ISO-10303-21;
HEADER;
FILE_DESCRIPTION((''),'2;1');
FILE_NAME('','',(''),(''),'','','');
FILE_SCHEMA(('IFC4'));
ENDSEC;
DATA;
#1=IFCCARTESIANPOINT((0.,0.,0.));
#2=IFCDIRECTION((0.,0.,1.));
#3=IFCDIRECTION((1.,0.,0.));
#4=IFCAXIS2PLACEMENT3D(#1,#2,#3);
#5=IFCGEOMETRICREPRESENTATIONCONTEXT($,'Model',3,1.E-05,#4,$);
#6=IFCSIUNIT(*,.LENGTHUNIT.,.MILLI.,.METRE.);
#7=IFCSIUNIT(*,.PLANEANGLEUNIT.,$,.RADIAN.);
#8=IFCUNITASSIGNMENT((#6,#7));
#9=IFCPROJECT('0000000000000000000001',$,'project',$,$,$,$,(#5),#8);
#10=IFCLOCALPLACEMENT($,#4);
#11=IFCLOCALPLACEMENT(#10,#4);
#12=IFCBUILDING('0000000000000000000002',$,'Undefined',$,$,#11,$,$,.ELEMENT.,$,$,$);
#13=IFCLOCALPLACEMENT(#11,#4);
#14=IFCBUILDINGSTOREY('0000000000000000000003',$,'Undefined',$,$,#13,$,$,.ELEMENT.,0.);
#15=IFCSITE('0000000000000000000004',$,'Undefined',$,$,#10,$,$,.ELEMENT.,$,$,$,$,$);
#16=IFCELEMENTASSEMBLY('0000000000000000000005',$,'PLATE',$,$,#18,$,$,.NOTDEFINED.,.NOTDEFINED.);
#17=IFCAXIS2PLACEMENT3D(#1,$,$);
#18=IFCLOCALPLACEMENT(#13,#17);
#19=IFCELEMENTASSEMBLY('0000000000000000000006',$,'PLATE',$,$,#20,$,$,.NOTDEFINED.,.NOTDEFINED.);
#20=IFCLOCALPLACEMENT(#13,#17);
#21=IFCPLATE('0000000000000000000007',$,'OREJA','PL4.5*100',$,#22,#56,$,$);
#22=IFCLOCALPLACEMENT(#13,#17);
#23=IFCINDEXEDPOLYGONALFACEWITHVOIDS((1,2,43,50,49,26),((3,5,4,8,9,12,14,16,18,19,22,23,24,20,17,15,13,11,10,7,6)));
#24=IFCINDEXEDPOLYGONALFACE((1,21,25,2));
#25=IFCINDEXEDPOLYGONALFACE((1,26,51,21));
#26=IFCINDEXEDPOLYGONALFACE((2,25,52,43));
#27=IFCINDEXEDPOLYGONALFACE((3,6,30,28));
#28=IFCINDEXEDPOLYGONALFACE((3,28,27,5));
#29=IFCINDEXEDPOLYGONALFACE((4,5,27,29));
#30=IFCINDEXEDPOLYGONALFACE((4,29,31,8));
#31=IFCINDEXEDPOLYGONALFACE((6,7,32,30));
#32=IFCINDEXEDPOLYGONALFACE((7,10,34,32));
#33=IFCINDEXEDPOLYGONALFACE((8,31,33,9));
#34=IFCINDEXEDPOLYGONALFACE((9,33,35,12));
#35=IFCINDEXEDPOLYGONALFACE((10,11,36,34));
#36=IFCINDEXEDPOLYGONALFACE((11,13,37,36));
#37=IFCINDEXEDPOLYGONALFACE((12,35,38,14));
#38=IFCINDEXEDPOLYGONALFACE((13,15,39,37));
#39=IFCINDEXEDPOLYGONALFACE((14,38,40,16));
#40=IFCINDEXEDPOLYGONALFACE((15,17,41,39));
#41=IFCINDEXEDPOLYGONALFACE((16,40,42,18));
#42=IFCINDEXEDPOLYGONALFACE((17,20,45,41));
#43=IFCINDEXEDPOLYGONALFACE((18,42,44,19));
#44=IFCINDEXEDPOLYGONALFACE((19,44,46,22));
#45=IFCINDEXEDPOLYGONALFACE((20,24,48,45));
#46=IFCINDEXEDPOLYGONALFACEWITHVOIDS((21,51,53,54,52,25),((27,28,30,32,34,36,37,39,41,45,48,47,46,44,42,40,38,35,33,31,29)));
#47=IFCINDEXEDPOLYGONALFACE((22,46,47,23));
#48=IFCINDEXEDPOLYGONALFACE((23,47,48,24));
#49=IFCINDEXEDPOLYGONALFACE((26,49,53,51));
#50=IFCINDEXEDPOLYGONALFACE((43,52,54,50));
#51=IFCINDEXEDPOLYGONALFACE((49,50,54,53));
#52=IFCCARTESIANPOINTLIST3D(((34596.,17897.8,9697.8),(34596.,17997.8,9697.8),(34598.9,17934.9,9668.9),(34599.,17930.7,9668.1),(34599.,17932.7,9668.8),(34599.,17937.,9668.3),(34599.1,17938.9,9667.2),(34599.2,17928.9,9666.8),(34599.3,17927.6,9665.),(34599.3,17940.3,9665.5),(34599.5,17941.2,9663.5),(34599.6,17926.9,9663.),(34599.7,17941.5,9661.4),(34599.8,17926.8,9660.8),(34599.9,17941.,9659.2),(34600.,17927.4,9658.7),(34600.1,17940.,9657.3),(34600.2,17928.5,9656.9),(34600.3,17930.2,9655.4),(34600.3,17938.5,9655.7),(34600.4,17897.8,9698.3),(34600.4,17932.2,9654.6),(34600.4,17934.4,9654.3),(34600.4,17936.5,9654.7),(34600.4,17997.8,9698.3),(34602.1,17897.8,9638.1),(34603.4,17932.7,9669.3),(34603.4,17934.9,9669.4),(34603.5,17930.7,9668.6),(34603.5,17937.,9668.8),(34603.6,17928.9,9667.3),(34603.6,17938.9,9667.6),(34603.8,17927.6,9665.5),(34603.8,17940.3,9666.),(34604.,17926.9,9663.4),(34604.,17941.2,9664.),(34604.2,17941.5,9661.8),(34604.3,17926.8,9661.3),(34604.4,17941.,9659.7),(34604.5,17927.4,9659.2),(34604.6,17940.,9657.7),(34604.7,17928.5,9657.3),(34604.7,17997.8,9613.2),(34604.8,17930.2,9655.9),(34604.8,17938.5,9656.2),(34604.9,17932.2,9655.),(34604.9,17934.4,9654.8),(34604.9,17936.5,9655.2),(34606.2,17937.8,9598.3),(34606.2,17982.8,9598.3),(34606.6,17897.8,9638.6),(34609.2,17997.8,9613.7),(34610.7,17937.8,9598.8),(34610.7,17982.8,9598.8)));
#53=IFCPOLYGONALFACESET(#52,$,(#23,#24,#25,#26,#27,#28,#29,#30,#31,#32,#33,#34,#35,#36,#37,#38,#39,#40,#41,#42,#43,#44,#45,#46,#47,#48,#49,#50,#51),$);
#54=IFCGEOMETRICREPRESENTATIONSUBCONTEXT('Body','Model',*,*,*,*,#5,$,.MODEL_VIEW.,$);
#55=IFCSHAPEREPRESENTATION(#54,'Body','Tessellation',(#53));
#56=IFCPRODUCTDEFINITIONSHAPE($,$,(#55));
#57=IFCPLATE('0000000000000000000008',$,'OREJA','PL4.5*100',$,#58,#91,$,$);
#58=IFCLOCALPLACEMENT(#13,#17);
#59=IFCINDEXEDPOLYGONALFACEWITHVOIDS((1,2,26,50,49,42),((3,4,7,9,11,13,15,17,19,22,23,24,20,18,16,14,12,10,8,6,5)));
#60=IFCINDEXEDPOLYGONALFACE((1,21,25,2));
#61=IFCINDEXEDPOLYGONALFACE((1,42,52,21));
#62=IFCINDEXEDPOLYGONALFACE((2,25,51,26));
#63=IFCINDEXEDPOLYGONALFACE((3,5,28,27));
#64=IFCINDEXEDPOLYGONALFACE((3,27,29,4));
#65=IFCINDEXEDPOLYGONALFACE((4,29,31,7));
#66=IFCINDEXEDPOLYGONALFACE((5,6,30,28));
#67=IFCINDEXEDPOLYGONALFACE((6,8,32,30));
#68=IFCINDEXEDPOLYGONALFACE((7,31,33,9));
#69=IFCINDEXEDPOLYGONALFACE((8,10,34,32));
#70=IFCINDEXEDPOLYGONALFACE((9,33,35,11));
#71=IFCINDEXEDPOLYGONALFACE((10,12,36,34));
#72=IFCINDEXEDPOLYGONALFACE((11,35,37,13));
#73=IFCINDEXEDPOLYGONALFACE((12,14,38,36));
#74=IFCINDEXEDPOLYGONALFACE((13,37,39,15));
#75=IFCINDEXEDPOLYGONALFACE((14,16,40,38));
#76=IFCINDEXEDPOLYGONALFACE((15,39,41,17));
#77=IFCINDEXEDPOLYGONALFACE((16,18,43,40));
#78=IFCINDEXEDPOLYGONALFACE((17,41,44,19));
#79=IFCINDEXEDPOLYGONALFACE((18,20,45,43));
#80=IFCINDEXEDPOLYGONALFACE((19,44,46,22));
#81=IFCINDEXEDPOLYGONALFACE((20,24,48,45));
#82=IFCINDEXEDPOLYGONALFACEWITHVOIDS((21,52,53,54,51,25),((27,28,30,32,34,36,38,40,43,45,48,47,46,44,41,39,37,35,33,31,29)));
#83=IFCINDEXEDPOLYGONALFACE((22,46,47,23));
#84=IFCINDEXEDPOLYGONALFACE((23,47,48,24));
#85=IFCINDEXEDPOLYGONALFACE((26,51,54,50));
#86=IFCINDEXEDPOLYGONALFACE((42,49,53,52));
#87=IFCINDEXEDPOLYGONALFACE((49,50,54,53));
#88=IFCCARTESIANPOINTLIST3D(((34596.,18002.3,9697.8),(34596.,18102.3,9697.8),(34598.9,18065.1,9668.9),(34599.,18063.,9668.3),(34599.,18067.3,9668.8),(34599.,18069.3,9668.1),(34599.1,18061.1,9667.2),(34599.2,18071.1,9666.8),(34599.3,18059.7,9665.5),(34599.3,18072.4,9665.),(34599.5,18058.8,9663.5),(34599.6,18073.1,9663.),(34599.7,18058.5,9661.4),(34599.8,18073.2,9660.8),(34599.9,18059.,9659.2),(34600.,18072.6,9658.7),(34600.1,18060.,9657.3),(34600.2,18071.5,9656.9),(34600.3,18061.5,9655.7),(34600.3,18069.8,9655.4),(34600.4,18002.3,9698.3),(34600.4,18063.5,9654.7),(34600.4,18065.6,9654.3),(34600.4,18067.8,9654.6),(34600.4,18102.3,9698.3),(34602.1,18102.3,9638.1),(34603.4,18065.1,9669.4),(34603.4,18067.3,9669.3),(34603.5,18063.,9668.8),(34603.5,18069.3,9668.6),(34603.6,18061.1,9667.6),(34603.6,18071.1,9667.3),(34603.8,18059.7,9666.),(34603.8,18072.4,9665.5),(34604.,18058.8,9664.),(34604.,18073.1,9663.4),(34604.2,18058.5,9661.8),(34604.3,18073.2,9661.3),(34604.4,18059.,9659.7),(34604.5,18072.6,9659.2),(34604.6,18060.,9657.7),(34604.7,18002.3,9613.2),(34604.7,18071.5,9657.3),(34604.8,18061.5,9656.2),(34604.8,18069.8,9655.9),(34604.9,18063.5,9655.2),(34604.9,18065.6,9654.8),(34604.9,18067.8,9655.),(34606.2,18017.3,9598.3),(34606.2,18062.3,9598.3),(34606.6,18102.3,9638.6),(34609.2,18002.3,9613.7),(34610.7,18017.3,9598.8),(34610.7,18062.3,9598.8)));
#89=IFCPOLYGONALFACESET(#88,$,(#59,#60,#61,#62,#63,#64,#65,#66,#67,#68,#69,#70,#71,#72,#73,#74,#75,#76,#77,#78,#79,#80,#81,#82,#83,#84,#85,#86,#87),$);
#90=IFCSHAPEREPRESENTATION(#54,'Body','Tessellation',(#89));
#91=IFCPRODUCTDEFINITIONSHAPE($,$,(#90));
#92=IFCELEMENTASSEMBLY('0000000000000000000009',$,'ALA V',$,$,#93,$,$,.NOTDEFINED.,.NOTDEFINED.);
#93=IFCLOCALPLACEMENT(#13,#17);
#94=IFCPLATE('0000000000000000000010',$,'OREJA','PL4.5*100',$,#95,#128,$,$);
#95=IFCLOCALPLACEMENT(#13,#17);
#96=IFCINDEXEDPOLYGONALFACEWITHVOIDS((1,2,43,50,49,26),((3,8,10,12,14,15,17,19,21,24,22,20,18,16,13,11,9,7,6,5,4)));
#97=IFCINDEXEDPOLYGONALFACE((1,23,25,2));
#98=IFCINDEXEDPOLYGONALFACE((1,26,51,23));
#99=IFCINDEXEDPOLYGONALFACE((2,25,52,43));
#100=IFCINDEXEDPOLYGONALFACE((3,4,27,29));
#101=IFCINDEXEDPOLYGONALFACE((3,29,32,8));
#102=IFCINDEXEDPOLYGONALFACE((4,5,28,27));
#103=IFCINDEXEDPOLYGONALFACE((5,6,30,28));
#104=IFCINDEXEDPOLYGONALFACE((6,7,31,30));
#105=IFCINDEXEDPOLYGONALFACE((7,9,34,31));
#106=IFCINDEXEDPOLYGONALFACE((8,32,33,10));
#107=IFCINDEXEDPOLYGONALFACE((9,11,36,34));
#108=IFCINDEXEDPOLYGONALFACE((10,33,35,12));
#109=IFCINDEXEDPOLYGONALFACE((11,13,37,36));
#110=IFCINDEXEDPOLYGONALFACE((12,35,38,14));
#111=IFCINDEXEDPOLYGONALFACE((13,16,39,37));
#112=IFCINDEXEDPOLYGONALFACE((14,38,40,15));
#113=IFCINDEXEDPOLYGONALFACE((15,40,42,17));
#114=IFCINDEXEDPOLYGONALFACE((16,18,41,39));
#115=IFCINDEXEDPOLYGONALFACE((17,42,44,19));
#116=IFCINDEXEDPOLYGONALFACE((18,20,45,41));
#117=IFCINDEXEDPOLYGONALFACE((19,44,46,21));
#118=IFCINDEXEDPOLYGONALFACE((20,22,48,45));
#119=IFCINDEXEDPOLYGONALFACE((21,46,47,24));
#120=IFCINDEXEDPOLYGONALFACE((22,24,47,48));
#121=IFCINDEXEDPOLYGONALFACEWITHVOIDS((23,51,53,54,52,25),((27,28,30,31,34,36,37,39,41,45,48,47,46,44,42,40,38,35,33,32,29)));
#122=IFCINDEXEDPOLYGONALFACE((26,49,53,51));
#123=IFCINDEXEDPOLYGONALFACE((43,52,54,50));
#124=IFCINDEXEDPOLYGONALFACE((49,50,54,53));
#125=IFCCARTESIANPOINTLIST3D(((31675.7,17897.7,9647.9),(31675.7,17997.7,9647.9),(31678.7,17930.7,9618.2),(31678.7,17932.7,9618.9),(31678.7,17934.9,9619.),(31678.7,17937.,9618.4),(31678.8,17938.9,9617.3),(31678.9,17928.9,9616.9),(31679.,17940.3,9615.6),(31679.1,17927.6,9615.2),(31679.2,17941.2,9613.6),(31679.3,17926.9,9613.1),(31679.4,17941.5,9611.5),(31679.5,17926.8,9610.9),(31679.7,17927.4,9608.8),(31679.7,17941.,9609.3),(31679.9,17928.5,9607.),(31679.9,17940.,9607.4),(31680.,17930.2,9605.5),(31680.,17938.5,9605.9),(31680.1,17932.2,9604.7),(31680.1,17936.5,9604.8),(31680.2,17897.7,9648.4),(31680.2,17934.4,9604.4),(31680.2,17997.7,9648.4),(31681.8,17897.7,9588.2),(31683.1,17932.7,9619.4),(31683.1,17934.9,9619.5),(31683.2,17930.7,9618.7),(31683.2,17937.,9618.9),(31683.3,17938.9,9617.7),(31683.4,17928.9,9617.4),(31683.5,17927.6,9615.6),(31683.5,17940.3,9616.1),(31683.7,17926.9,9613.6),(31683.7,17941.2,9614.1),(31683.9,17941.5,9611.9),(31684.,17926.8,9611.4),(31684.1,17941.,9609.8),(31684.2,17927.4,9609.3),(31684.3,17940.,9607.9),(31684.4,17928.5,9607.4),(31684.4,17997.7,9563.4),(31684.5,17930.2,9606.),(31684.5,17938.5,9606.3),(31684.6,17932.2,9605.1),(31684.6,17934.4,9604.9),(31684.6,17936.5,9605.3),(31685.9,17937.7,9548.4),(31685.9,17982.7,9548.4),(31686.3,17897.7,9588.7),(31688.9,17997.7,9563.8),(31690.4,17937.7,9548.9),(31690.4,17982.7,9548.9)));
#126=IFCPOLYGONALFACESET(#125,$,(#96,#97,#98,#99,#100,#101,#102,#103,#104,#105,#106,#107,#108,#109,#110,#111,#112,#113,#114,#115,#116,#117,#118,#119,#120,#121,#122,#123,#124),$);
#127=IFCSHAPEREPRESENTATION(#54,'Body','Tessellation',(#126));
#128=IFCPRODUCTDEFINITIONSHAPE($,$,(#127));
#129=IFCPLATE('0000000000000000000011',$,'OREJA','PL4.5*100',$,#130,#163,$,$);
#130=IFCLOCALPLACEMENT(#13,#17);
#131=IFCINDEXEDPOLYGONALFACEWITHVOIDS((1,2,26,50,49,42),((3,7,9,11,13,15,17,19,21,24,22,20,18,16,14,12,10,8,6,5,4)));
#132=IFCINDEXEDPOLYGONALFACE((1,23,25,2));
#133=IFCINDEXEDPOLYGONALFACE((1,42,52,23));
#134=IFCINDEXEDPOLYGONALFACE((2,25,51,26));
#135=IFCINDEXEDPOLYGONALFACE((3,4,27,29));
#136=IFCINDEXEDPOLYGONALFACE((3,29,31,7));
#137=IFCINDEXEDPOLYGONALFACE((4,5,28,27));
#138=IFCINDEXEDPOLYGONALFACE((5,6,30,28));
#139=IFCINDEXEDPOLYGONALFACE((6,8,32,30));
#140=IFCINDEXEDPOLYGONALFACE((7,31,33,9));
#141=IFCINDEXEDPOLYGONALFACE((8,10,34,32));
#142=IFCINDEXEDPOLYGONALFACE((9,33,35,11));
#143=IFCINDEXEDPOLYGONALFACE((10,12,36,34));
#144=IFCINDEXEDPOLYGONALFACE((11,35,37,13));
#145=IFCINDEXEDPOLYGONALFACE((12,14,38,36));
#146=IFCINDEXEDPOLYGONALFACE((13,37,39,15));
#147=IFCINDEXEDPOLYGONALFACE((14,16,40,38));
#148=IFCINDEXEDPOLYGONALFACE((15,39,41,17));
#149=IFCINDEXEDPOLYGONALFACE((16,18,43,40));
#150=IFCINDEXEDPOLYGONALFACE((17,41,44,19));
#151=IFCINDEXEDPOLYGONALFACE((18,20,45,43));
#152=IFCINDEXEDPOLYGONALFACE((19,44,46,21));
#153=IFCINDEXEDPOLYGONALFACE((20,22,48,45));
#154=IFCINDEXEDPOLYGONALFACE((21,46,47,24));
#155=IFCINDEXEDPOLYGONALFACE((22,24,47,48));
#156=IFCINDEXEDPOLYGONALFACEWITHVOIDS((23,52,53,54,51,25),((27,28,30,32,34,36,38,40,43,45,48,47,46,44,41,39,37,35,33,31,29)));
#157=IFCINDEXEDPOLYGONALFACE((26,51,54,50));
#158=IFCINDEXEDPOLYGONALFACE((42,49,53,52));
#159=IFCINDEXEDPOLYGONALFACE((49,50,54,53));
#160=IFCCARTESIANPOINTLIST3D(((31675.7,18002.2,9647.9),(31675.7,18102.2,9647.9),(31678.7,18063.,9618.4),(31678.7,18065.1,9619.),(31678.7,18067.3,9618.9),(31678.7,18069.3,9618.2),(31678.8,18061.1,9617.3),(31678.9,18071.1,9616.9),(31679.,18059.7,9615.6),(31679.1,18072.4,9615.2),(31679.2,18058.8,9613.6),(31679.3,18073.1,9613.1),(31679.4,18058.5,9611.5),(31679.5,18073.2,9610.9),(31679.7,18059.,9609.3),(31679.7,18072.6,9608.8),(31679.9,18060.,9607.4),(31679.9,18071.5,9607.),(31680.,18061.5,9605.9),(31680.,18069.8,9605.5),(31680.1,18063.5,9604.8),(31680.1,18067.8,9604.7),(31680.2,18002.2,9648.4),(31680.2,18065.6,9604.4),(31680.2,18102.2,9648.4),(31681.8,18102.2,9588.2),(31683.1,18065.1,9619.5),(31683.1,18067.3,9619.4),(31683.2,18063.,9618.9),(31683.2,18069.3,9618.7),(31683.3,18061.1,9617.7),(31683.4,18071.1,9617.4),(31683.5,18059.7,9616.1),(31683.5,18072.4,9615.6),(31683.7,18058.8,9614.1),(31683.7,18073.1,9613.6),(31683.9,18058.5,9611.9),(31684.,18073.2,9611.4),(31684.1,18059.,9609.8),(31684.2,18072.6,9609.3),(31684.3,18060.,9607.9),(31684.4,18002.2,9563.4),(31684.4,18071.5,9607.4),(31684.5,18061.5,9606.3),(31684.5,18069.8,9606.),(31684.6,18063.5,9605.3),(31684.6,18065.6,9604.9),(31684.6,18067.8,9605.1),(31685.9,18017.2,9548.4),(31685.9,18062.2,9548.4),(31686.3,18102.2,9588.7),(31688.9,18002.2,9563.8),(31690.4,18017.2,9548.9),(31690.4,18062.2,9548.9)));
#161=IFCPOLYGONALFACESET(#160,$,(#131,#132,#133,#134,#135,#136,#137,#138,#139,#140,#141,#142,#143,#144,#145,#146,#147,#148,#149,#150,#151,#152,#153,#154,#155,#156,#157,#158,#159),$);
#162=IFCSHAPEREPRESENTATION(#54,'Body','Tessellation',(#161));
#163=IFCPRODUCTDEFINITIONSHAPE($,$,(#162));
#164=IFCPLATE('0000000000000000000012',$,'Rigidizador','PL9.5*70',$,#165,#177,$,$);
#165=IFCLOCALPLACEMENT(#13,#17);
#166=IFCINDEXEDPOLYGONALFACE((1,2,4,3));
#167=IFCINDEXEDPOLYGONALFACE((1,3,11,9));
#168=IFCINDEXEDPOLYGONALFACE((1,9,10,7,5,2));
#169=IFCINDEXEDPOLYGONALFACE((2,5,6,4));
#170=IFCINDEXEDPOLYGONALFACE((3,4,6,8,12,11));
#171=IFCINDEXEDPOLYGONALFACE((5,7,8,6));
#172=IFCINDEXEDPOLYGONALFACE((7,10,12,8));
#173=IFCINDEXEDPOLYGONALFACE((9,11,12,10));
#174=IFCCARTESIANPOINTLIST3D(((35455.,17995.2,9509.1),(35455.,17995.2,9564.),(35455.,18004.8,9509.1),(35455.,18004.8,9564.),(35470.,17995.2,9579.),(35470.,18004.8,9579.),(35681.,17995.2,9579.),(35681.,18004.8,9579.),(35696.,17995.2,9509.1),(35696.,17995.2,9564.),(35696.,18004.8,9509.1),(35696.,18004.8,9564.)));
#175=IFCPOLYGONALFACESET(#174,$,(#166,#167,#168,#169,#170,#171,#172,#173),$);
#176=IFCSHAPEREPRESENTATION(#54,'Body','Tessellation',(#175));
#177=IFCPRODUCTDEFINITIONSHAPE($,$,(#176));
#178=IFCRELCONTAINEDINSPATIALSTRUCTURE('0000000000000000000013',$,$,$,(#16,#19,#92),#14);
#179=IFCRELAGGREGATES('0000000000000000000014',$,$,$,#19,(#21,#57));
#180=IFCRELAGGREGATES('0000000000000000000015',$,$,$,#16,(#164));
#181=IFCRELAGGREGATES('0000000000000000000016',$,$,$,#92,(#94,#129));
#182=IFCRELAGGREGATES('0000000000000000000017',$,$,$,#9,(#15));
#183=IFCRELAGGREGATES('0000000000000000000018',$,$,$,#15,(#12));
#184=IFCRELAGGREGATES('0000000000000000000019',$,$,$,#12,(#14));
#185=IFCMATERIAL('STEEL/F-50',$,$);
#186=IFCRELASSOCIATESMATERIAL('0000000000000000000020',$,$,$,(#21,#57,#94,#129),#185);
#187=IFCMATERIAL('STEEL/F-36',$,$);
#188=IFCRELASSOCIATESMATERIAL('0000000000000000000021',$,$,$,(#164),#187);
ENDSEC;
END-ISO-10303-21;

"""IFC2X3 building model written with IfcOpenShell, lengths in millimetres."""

from ifc_helpers import new_model, si_unit, frame, origin_with_axes, origin_2d_with_axis, place, context, subcontext, project, spatial, polyline, circle, outline, extrude, source, transform, mapped, material, element, aggregate, save


model = new_model("IFC2X3")

# Units and contexts
model_context = context("Model", 3, precision=1e-05, world=origin_with_axes())
body_context = subcontext(model_context, "Body", "Model", "MODEL_VIEW")
ifc_project = project(units=[si_unit("LENGTHUNIT", "METRE", prefix="MILLI"), si_unit("PLANEANGLEUNIT", "RADIAN")], contexts=[model_context])

# Site, building, storey
site_placement = place(None, origin_with_axes())
site = spatial("IfcSite", under=ifc_project, at=site_placement, Name="Undefined", CompositionType="ELEMENT")
building_placement = place(site_placement, origin_with_axes())
building = spatial("IfcBuilding", under=site, at=building_placement, Name="Undefined", CompositionType="ELEMENT")
storey_placement = place(building_placement, origin_with_axes())
storey = spatial("IfcBuildingStorey", under=building, at=storey_placement, Name="Undefined", CompositionType="ELEMENT", Elevation=0.0)

# Element assembly
assembly_1_placement = place(storey_placement, origin_with_axes())
assembly_1 = element("IfcElementAssembly", 1, at=assembly_1_placement, inside=storey, Name="PLATE", AssemblyPlace="NOTDEFINED", PredefinedType="NOTDEFINED")
ifc_material_1 = material(Name="STEEL/F-36")

# Element assemblies, plates, openings
assembly_2_placement = place(storey_placement, origin_with_axes())
assembly_2 = element("IfcElementAssembly", 2, at=assembly_2_placement, inside=storey, Name="PLATE", AssemblyPlace="NOTDEFINED", PredefinedType="NOTDEFINED")
ifc_material_2 = material(Name="STEEL/F-50")
plate_1_placement = place(assembly_2_placement, frame((34608.5, 17997.8, 9598.6), z_axis=(-0.994727, 0.0, -0.102562), x_axis=(0.0, -1.0, 0.0)))
plate_1 = element("IfcPlate", 3, at=plate_1_placement, material=ifc_material_2, Name="OREJA", Description="PL4.5*100", context=body_context, shape_type="SweptSolid", body=[
    extrude(outline(polyline([(0.0, 15.0), (15.0, 0.0), (60.0, 0.0), (100.0, 40.0), (100.0, 100.0), (0.0, 100.0), (0.0, 15.0)])), frame((0.0, 0.0, -2.2), z_axis=(0.0, 0.0, 1.0), x_axis=(1.0, 0.0, 0.0)), (0.0, 0.0, 1.0), 4.5),
])
shared_shape_1 = source(origin_with_axes(), body_context, "Body", "SweptSolid", [
    extrude(circle(Radius=7.3, at=origin_2d_with_axis()), frame((0.0, -0.1, 0.0), z_axis=(0.0, 1.0, 0.0), x_axis=(1.0, 0.0, 0.0)), (0.0, 0.0, 1.0), 4.7),
])
opening_1_placement = place(assembly_2_placement, frame((34604.2, 17934.1, 9662.1), z_axis=(0.072522, -0.707107, -0.703378), x_axis=(-0.072522, -0.707107, 0.703378)))
element("IfcOpeningElement", 4, at=opening_1_placement, cuts=plate_1, ObjectType="Opening", context=body_context, shape_type="MappedRepresentation", body=[
    mapped(shared_shape_1, transform((0.0, 0.0, 0.0))),
])
plate_2_placement = place(assembly_2_placement, frame((34608.5, 18002.3, 9598.6), z_axis=(0.994727, 0.0, 0.102562), x_axis=(0.0, 1.0, 0.0)))
plate_2 = element("IfcPlate", 5, at=plate_2_placement, material=ifc_material_2, Name="OREJA", Description="PL4.5*100", context=body_context, shape_type="SweptSolid", body=[
    extrude(outline(polyline([(0.0, 15.0), (15.0, 0.0), (60.0, 0.0), (100.0, 40.0), (100.0, 100.0), (0.0, 100.0), (0.0, 15.0)])), frame((0.0, 0.0, -2.2), z_axis=(0.0, 0.0, 1.0), x_axis=(1.0, 0.0, 0.0)), (0.0, 0.0, 1.0), 4.5),
])
opening_2_placement = place(assembly_2_placement, frame((34604.2, 18065.9, 9662.1), z_axis=(-0.072522, -0.707107, 0.703378), x_axis=(-0.072522, 0.707107, 0.703378)))
element("IfcOpeningElement", 6, at=opening_2_placement, cuts=plate_2, ObjectType="Opening", context=body_context, shape_type="MappedRepresentation", body=[
    mapped(shared_shape_1, transform((0.0, 0.0, 0.0))),
])
aggregate(assembly_2, [plate_1, plate_2])
assembly_3_placement = place(storey_placement, origin_with_axes())
assembly_3 = element("IfcElementAssembly", 7, at=assembly_3_placement, inside=storey, Name="ALA V", AssemblyPlace="NOTDEFINED", PredefinedType="NOTDEFINED")
plate_3_placement = place(assembly_3_placement, frame((31688.2, 17997.7, 9548.7), z_axis=(-0.994727, 0.0, -0.102562), x_axis=(0.0, -1.0, 0.0)))
plate_3 = element("IfcPlate", 8, at=plate_3_placement, material=ifc_material_2, Name="OREJA", Description="PL4.5*100", context=body_context, shape_type="SweptSolid", body=[
    extrude(outline(polyline([(0.0, 15.0), (15.0, 0.0), (60.0, 0.0), (100.0, 40.0), (100.0, 100.0), (0.0, 100.0), (0.0, 15.0)])), frame((0.0, 0.0, -2.2), z_axis=(0.0, 0.0, 1.0), x_axis=(1.0, 0.0, 0.0)), (0.0, 0.0, 1.0), 4.5),
])
opening_3_placement = place(assembly_3_placement, frame((31683.9, 17934.1, 9612.2), z_axis=(0.072522, -0.707107, -0.703378), x_axis=(-0.072522, -0.707107, 0.703378)))
element("IfcOpeningElement", 9, at=opening_3_placement, cuts=plate_3, ObjectType="Opening", context=body_context, shape_type="MappedRepresentation", body=[
    mapped(shared_shape_1, transform((0.0, 0.0, 0.0))),
])
plate_4_placement = place(assembly_3_placement, frame((31688.2, 18002.2, 9548.7), z_axis=(0.994727, 0.0, 0.102562), x_axis=(0.0, 1.0, 0.0)))
plate_4 = element("IfcPlate", 10, at=plate_4_placement, material=ifc_material_2, Name="OREJA", Description="PL4.5*100", context=body_context, shape_type="SweptSolid", body=[
    extrude(outline(polyline([(0.0, 15.0), (15.0, 0.0), (60.0, 0.0), (100.0, 40.0), (100.0, 100.0), (0.0, 100.0), (0.0, 15.0)])), frame((0.0, 0.0, -2.2), z_axis=(0.0, 0.0, 1.0), x_axis=(1.0, 0.0, 0.0)), (0.0, 0.0, 1.0), 4.5),
])
opening_4_placement = place(assembly_3_placement, frame((31683.9, 18065.9, 9612.2), z_axis=(-0.072522, -0.707107, 0.703378), x_axis=(-0.072522, 0.707107, 0.703378)))
element("IfcOpeningElement", 11, at=opening_4_placement, cuts=plate_4, ObjectType="Opening", context=body_context, shape_type="MappedRepresentation", body=[
    mapped(shared_shape_1, transform((0.0, 0.0, 0.0))),
])

# Plate
plate_5_placement = place(assembly_1_placement, frame((35455.0, 18000.0, 9509.1), z_axis=(0.0, -1.0, 0.0), x_axis=(1.0, 0.0, 0.0)))
plate_5 = element("IfcPlate", 12, at=plate_5_placement, material=ifc_material_1, Name="Rigidizador", Description="PL9.5*70", context=body_context, shape_type="SweptSolid", body=[
    extrude(outline(polyline([(0.0, 0.0), (241.0, 0.0), (241.0, 54.9), (226.0, 69.9), (15.0, 69.9), (0.0, 54.9), (0.0, 0.0)])), frame((0.0, 0.0, -4.8), z_axis=(0.0, 0.0, 1.0), x_axis=(1.0, 0.0, 0.0)), (0.0, 0.0, 1.0), 9.5),
])
aggregate(assembly_1, [plate_5])

aggregate(assembly_3, [plate_3, plate_4])

save(model, "model.ifc")
